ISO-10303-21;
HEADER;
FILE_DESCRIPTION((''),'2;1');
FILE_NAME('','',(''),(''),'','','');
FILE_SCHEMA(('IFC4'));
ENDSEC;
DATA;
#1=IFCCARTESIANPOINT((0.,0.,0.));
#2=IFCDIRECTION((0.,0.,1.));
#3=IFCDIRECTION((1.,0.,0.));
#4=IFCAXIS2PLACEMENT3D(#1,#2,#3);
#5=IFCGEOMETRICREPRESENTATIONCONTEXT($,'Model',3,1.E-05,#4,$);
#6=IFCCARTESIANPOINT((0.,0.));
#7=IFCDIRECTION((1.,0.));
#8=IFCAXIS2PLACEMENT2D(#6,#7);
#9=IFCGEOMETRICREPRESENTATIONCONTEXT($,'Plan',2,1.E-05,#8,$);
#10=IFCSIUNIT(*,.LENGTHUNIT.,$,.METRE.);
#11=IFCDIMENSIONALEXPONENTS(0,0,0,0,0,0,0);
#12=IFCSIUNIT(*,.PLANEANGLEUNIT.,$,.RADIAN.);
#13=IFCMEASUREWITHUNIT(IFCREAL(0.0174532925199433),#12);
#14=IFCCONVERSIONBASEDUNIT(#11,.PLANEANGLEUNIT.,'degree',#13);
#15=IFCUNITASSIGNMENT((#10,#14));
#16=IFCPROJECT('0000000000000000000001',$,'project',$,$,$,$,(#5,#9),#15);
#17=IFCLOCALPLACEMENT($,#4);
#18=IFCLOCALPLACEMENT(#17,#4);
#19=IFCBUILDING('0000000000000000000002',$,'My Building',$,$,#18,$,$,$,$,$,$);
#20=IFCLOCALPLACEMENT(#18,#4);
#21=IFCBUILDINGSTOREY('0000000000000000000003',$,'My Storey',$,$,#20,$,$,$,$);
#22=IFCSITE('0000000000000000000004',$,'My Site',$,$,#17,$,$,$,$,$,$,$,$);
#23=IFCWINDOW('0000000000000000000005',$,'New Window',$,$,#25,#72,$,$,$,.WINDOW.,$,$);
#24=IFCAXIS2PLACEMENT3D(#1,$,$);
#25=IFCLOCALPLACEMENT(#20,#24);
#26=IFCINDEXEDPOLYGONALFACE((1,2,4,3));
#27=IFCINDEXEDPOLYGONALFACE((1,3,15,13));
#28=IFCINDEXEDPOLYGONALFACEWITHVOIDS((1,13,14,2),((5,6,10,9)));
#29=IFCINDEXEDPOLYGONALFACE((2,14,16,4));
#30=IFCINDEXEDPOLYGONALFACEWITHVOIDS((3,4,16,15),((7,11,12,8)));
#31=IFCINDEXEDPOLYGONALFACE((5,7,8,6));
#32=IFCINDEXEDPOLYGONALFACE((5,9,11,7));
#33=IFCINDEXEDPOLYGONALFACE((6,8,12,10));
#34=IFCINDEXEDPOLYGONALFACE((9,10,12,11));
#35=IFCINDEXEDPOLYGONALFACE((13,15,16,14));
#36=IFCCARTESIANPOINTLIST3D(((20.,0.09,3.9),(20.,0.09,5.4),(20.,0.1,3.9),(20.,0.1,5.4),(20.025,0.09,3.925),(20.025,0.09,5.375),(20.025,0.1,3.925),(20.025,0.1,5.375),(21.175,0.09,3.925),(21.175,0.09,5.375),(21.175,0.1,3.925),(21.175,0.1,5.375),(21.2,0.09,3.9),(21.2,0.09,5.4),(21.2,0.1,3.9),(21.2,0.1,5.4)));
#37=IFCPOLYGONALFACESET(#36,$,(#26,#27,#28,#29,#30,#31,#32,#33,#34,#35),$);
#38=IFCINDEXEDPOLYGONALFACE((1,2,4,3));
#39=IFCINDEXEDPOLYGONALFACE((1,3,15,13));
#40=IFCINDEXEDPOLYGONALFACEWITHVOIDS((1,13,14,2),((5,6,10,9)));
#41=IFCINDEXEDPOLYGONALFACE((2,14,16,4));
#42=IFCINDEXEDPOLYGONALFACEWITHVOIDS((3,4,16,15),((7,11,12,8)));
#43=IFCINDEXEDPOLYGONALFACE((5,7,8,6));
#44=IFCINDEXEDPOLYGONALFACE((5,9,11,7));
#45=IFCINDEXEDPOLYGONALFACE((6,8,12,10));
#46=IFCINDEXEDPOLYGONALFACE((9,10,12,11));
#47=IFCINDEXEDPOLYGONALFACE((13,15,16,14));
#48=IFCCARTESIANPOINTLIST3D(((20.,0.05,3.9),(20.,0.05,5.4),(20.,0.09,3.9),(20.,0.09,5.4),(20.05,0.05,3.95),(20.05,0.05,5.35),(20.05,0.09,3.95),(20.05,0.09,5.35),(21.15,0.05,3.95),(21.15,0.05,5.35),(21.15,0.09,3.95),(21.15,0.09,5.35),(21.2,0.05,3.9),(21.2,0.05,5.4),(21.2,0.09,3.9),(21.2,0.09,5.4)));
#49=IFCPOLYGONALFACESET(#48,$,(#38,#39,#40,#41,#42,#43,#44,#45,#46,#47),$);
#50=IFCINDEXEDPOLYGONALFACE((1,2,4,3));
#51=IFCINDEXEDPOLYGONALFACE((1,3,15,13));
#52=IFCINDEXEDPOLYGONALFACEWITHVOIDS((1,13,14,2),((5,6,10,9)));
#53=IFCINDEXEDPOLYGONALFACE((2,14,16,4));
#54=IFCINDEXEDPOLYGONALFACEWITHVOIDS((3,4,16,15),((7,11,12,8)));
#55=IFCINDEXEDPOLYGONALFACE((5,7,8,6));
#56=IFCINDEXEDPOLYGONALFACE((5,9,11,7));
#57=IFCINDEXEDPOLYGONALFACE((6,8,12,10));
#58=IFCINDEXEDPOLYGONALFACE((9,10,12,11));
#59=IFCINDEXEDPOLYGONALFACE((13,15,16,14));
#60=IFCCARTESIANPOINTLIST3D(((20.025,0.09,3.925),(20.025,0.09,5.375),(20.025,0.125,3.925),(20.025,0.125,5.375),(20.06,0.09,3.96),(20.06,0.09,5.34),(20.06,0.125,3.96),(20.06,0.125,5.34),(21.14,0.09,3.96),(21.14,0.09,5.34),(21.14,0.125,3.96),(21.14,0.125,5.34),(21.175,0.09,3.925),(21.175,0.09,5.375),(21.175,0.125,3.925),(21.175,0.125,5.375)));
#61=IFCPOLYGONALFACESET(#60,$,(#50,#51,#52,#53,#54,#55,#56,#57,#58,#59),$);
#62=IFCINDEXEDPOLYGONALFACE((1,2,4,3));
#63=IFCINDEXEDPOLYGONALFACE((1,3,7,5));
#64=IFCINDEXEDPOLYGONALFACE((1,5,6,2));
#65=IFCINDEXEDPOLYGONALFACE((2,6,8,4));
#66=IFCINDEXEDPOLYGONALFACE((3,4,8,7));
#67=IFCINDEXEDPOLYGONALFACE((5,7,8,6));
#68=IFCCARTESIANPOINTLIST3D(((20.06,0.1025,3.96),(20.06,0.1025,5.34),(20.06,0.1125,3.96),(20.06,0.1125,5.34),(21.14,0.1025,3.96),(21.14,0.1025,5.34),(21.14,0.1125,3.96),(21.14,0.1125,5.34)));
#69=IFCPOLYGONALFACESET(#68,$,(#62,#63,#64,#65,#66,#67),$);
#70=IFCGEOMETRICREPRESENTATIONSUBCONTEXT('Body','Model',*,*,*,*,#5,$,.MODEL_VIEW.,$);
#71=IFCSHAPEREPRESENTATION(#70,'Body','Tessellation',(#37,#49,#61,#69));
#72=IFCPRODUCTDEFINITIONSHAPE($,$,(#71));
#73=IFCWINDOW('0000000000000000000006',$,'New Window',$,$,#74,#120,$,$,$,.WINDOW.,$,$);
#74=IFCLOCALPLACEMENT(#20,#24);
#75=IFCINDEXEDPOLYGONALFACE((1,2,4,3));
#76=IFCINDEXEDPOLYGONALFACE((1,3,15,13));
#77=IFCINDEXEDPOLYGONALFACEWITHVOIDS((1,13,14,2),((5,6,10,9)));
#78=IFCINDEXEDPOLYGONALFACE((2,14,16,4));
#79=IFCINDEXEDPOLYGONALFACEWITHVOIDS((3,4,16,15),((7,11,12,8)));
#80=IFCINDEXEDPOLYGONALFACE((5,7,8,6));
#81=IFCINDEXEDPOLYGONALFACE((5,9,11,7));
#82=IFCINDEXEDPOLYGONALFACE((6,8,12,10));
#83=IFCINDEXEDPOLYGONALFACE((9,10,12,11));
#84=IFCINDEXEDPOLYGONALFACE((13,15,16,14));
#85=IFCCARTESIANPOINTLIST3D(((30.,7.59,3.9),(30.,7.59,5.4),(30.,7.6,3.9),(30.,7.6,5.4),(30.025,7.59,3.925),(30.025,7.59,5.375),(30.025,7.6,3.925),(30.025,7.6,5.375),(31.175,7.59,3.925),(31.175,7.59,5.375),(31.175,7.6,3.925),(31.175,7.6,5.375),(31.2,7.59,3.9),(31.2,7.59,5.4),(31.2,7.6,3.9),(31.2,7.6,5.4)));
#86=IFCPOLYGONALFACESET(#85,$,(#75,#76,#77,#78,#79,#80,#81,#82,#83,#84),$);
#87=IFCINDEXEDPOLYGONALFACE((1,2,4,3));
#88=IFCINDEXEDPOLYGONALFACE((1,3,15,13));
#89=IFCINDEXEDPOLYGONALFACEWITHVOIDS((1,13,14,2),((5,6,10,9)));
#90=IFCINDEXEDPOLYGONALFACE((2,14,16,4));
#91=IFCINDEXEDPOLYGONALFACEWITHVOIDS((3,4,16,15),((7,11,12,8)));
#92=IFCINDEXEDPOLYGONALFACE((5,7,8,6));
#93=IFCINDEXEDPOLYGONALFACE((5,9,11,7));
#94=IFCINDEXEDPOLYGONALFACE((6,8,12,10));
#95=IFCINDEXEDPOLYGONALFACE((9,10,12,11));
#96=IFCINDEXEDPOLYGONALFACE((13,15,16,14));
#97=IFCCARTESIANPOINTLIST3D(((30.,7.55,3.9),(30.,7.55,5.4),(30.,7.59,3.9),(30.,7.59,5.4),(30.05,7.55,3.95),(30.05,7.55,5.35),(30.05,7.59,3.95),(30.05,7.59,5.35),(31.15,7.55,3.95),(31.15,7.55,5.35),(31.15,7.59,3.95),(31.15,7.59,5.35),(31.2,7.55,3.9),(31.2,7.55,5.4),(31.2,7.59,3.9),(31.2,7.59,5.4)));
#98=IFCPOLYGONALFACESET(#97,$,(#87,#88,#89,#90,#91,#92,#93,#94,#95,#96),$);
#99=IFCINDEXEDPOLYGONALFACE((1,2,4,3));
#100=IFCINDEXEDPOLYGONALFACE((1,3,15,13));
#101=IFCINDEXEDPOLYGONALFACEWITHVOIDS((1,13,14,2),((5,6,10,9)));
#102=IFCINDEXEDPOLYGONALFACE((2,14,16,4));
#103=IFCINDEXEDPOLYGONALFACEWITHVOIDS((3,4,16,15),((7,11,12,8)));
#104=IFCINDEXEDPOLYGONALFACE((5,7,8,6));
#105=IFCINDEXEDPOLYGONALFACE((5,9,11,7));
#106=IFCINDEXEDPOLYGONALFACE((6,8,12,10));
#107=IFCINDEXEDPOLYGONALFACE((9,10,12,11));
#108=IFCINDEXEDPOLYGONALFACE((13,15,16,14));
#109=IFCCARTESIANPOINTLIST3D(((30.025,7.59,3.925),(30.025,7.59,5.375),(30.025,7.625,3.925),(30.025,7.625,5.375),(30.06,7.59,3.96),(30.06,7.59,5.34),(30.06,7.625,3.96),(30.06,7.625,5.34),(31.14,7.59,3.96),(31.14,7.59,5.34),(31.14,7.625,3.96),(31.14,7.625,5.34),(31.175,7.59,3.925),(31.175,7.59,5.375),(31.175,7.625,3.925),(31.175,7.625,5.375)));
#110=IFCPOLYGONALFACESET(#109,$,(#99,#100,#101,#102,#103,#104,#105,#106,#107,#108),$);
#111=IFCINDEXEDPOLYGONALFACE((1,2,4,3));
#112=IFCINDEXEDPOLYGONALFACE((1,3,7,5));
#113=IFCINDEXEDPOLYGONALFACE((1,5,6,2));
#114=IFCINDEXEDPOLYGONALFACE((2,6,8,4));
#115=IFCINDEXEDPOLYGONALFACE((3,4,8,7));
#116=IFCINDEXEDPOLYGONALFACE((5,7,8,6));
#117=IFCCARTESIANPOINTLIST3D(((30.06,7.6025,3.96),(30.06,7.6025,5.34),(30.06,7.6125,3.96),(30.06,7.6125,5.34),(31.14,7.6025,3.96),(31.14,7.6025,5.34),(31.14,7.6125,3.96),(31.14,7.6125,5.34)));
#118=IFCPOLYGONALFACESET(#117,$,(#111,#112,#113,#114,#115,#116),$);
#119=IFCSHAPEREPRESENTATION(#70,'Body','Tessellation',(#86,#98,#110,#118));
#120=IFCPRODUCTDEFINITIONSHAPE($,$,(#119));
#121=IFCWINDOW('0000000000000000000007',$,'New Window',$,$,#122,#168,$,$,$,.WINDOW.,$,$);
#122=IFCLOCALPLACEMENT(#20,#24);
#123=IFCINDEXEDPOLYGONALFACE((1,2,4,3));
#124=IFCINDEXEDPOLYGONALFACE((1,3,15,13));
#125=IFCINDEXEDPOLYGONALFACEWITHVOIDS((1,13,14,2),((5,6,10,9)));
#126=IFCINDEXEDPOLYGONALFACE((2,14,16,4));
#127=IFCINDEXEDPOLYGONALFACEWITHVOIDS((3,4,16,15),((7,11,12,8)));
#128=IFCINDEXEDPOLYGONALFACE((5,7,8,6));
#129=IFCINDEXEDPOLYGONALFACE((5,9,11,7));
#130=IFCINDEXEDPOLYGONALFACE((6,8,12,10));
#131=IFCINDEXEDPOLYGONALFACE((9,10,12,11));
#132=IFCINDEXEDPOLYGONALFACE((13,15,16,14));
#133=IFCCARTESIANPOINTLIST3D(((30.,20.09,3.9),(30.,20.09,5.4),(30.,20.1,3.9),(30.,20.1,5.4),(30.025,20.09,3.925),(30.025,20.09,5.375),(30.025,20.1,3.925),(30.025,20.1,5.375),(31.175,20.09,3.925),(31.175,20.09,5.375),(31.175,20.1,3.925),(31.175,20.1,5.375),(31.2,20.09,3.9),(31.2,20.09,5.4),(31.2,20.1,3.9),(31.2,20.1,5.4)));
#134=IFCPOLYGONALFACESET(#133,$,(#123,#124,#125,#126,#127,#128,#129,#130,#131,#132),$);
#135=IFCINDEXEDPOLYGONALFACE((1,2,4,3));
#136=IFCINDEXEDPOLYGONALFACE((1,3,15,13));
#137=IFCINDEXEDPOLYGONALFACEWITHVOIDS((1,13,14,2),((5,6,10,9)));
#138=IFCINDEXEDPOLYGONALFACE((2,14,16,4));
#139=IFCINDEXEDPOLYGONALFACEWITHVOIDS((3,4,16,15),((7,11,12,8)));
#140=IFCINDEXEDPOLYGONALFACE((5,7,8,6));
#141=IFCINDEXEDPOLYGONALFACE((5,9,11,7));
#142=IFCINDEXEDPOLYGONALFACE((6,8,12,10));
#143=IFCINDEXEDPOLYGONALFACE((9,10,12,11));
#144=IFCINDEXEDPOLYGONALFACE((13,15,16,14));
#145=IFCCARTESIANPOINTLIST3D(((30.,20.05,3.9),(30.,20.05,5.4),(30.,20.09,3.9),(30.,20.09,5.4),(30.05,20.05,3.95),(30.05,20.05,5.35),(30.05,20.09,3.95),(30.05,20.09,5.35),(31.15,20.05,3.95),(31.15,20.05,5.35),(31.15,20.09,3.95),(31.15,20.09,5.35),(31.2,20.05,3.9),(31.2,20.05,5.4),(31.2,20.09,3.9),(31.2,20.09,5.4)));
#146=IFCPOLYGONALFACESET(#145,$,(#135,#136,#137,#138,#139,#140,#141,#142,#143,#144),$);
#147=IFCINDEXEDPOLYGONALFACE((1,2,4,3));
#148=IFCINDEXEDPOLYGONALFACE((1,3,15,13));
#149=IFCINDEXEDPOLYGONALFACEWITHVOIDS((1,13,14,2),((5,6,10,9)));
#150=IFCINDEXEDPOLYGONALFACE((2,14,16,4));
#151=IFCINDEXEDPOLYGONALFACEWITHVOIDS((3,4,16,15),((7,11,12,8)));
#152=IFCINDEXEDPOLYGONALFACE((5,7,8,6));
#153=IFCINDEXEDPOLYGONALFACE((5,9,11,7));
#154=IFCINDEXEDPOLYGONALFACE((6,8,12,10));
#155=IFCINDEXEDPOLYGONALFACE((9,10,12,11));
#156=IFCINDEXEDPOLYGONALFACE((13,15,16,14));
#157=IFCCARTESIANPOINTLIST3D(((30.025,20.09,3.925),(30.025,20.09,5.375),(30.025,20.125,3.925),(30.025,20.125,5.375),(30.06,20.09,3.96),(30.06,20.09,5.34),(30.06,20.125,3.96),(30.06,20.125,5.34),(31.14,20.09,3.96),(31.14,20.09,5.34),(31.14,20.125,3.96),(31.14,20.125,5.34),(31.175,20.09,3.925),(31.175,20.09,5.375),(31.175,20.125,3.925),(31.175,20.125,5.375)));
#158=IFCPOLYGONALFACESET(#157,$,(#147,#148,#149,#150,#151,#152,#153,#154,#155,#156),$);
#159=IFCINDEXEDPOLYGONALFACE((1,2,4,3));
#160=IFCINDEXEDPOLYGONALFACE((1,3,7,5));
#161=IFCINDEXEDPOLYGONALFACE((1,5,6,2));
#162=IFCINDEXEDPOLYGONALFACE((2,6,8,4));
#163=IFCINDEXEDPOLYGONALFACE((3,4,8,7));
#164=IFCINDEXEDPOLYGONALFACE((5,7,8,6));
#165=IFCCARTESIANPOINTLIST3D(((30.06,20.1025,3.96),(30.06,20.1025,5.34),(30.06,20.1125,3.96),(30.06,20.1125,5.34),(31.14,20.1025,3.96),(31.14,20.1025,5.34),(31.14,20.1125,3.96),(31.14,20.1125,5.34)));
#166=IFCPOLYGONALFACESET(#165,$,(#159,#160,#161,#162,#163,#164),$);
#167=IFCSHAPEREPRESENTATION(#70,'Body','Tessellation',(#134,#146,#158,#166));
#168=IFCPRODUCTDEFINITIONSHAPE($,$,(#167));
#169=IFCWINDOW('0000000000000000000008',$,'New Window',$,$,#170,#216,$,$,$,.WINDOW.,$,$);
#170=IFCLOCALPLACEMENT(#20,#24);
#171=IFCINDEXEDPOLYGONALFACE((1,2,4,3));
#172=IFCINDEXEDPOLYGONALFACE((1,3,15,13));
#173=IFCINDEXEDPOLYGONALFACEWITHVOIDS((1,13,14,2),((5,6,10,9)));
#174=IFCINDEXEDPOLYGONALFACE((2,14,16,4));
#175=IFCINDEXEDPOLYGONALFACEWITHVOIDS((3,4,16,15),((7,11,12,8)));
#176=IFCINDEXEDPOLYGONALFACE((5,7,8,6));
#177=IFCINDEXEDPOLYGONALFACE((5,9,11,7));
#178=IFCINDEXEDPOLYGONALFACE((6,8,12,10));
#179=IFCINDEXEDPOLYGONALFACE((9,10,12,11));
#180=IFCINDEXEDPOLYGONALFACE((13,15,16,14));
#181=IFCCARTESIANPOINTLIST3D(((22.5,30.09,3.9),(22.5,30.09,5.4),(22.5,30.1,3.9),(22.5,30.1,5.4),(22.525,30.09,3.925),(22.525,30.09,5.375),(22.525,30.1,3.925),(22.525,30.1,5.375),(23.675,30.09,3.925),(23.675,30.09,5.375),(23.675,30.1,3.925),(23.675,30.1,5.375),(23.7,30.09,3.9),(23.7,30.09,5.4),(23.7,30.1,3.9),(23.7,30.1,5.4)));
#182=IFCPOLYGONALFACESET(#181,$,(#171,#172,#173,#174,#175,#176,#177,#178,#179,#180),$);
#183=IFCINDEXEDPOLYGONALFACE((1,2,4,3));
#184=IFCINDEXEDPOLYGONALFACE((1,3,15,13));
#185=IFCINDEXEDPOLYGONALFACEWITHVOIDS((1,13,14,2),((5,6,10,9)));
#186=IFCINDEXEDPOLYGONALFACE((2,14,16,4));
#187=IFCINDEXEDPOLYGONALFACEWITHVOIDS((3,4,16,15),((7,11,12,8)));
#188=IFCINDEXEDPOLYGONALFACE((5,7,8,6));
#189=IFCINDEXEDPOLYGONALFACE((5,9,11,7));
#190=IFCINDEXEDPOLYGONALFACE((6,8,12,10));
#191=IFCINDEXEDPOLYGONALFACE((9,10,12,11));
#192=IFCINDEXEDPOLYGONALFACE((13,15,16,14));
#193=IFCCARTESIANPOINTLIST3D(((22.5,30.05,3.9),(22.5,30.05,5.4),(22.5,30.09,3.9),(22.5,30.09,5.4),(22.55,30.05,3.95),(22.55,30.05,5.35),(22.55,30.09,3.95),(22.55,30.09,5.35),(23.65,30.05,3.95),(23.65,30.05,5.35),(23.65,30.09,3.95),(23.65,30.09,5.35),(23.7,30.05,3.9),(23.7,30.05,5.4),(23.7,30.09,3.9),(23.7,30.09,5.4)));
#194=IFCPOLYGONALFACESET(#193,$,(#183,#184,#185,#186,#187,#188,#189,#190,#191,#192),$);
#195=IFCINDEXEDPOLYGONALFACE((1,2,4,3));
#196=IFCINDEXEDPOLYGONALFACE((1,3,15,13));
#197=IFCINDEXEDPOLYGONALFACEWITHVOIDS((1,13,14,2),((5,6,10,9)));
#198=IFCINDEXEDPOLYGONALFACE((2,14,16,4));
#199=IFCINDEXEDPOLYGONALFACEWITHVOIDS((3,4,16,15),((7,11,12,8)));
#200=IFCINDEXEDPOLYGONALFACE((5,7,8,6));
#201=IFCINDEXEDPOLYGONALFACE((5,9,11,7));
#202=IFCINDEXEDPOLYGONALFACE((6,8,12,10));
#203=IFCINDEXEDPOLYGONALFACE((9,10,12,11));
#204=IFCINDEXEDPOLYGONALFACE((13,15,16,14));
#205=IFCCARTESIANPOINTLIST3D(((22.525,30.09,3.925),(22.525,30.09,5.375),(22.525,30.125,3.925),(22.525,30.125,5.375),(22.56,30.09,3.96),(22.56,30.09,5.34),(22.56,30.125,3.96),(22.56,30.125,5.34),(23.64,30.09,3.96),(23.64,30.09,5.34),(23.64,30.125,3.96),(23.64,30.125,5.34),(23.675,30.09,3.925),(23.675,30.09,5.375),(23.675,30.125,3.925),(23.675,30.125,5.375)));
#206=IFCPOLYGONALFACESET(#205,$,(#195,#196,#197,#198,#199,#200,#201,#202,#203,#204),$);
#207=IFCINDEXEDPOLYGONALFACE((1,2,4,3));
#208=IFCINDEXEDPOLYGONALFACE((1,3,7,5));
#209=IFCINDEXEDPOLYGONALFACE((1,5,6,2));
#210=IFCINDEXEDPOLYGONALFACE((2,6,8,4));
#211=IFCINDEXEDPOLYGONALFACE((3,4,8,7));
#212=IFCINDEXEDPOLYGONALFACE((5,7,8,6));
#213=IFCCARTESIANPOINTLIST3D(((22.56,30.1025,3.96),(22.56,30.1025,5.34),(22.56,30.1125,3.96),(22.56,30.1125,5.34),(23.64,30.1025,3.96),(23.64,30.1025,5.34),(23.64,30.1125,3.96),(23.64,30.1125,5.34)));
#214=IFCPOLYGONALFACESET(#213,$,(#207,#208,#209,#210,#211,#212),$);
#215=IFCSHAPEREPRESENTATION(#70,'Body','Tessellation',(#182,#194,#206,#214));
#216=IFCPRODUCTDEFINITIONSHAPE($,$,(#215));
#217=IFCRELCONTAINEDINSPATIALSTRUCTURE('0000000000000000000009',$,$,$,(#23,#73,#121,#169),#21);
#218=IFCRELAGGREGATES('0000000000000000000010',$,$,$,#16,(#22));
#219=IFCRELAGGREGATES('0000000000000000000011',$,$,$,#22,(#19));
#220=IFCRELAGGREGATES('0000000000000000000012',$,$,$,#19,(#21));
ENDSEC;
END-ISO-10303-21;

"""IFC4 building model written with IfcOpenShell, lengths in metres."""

from ifc_helpers import new_model, entity, si_unit, converted_unit, frame, origin_with_axes, origin_2d_with_axis, place, context, subcontext, project, spatial, line, indexed_curve, outline, extrude, element, save


model = new_model("IFC4")

# Units and contexts
model_context = context("Model", 3, precision=1e-05, world=origin_with_axes())
plan_context = context("Plan", 2, precision=1e-05, world=origin_2d_with_axis())
body_context = subcontext(model_context, "Body", "Model", "MODEL_VIEW")
ifc_project = project(units=[si_unit("LENGTHUNIT", "METRE"), converted_unit("PLANEANGLEUNIT", "degree", entity("IfcReal", 0.0174532925199433), si_unit("PLANEANGLEUNIT", "RADIAN"), dimensions=[0, 0, 0, 0, 0, 0, 0])], contexts=[model_context, plan_context])

# Site, building, storey
site_placement = place(None, origin_with_axes())
site = spatial("IfcSite", under=ifc_project, at=site_placement, Name="My Site")
building_placement = place(site_placement, origin_with_axes())
building = spatial("IfcBuilding", under=site, at=building_placement, Name="My Building")
storey_placement = place(building_placement, origin_with_axes())
storey = spatial("IfcBuildingStorey", under=building, at=storey_placement, Name="My Storey")

# Windows
for number, where, z_axis, x_axis, name in (
    (1, (20.0, 0.0, 3.9), (0.0, 0.0, 1.0), (1.0, 0.0, 0.0), "New Window"),
    (2, (30.0, 7.5, 3.9), (0.0, 0.0, 1.0), (1.0, 0.0, 0.0), "New Window"),
    (3, (30.0, 20.0, 3.9), (0.0, 0.0, 1.0), (1.0, 0.0, 0.0), "New Window"),
    (4, (22.5, 30.0, 3.9), (0.0, 0.0, 1.0), (1.0, 0.0, 0.0), "New Window"),
):
    element("IfcWindow", number, at=place(storey_placement, frame(where, z_axis=z_axis, x_axis=x_axis)), inside=storey, Name=name, PredefinedType="WINDOW", context=body_context, shape_type="SweptSolid", body=[
        extrude(outline(indexed_curve([(0.0, 0.0), (1.2, 0.0), (1.2, 1.5), (0.0, 1.5)], segments=[line(1, 2, 3, 4, 1)]), holes=[indexed_curve([(0.025, 0.025), (1.175, 0.025), (1.175, 1.475), (0.025, 1.475)], segments=[line(1, 2, 3, 4, 1)])]), frame((0.0, 0.09, 0.0), z_axis=(0.0, -1.0, 0.0), x_axis=(1.0, 0.0, 0.0)), (0.0, 0.0, -1.0), 0.01),
        extrude(outline(indexed_curve([(0.0, 0.0), (1.2, 0.0), (1.2, 1.5), (0.0, 1.5)], segments=[line(1, 2, 3, 4, 1)]), holes=[indexed_curve([(0.05, 0.05), (1.15, 0.05), (1.15, 1.45), (0.05, 1.45)], segments=[line(1, 2, 3, 4, 1)])]), frame((0.0, 0.05, 0.0), z_axis=(0.0, -1.0, 0.0), x_axis=(1.0, 0.0, 0.0)), (0.0, 0.0, -1.0), 0.04),
        extrude(outline(indexed_curve([(0.0, 0.0), (1.15, 0.0), (1.15, 1.45), (0.0, 1.45)], segments=[line(1, 2, 3, 4, 1)]), holes=[indexed_curve([(0.035, 0.035), (1.115, 0.035), (1.115, 1.415), (0.035, 1.415)], segments=[line(1, 2, 3, 4, 1)])]), frame((0.025, 0.09, 0.025), z_axis=(0.0, -1.0, 0.0), x_axis=(1.0, 0.0, 0.0)), (0.0, 0.0, -1.0), 0.035),
        extrude(outline(indexed_curve([(0.035, 0.035), (1.115, 0.035), (1.115, 1.415), (0.035, 1.415)], segments=[line(1, 2, 3, 4, 1)])), frame((0.025, 0.1025, 0.025), z_axis=(0.0, -1.0, 0.0), x_axis=(1.0, 0.0, 0.0)), (0.0, 0.0, -1.0), 0.01),
    ])

save(model, "model.ifc")
